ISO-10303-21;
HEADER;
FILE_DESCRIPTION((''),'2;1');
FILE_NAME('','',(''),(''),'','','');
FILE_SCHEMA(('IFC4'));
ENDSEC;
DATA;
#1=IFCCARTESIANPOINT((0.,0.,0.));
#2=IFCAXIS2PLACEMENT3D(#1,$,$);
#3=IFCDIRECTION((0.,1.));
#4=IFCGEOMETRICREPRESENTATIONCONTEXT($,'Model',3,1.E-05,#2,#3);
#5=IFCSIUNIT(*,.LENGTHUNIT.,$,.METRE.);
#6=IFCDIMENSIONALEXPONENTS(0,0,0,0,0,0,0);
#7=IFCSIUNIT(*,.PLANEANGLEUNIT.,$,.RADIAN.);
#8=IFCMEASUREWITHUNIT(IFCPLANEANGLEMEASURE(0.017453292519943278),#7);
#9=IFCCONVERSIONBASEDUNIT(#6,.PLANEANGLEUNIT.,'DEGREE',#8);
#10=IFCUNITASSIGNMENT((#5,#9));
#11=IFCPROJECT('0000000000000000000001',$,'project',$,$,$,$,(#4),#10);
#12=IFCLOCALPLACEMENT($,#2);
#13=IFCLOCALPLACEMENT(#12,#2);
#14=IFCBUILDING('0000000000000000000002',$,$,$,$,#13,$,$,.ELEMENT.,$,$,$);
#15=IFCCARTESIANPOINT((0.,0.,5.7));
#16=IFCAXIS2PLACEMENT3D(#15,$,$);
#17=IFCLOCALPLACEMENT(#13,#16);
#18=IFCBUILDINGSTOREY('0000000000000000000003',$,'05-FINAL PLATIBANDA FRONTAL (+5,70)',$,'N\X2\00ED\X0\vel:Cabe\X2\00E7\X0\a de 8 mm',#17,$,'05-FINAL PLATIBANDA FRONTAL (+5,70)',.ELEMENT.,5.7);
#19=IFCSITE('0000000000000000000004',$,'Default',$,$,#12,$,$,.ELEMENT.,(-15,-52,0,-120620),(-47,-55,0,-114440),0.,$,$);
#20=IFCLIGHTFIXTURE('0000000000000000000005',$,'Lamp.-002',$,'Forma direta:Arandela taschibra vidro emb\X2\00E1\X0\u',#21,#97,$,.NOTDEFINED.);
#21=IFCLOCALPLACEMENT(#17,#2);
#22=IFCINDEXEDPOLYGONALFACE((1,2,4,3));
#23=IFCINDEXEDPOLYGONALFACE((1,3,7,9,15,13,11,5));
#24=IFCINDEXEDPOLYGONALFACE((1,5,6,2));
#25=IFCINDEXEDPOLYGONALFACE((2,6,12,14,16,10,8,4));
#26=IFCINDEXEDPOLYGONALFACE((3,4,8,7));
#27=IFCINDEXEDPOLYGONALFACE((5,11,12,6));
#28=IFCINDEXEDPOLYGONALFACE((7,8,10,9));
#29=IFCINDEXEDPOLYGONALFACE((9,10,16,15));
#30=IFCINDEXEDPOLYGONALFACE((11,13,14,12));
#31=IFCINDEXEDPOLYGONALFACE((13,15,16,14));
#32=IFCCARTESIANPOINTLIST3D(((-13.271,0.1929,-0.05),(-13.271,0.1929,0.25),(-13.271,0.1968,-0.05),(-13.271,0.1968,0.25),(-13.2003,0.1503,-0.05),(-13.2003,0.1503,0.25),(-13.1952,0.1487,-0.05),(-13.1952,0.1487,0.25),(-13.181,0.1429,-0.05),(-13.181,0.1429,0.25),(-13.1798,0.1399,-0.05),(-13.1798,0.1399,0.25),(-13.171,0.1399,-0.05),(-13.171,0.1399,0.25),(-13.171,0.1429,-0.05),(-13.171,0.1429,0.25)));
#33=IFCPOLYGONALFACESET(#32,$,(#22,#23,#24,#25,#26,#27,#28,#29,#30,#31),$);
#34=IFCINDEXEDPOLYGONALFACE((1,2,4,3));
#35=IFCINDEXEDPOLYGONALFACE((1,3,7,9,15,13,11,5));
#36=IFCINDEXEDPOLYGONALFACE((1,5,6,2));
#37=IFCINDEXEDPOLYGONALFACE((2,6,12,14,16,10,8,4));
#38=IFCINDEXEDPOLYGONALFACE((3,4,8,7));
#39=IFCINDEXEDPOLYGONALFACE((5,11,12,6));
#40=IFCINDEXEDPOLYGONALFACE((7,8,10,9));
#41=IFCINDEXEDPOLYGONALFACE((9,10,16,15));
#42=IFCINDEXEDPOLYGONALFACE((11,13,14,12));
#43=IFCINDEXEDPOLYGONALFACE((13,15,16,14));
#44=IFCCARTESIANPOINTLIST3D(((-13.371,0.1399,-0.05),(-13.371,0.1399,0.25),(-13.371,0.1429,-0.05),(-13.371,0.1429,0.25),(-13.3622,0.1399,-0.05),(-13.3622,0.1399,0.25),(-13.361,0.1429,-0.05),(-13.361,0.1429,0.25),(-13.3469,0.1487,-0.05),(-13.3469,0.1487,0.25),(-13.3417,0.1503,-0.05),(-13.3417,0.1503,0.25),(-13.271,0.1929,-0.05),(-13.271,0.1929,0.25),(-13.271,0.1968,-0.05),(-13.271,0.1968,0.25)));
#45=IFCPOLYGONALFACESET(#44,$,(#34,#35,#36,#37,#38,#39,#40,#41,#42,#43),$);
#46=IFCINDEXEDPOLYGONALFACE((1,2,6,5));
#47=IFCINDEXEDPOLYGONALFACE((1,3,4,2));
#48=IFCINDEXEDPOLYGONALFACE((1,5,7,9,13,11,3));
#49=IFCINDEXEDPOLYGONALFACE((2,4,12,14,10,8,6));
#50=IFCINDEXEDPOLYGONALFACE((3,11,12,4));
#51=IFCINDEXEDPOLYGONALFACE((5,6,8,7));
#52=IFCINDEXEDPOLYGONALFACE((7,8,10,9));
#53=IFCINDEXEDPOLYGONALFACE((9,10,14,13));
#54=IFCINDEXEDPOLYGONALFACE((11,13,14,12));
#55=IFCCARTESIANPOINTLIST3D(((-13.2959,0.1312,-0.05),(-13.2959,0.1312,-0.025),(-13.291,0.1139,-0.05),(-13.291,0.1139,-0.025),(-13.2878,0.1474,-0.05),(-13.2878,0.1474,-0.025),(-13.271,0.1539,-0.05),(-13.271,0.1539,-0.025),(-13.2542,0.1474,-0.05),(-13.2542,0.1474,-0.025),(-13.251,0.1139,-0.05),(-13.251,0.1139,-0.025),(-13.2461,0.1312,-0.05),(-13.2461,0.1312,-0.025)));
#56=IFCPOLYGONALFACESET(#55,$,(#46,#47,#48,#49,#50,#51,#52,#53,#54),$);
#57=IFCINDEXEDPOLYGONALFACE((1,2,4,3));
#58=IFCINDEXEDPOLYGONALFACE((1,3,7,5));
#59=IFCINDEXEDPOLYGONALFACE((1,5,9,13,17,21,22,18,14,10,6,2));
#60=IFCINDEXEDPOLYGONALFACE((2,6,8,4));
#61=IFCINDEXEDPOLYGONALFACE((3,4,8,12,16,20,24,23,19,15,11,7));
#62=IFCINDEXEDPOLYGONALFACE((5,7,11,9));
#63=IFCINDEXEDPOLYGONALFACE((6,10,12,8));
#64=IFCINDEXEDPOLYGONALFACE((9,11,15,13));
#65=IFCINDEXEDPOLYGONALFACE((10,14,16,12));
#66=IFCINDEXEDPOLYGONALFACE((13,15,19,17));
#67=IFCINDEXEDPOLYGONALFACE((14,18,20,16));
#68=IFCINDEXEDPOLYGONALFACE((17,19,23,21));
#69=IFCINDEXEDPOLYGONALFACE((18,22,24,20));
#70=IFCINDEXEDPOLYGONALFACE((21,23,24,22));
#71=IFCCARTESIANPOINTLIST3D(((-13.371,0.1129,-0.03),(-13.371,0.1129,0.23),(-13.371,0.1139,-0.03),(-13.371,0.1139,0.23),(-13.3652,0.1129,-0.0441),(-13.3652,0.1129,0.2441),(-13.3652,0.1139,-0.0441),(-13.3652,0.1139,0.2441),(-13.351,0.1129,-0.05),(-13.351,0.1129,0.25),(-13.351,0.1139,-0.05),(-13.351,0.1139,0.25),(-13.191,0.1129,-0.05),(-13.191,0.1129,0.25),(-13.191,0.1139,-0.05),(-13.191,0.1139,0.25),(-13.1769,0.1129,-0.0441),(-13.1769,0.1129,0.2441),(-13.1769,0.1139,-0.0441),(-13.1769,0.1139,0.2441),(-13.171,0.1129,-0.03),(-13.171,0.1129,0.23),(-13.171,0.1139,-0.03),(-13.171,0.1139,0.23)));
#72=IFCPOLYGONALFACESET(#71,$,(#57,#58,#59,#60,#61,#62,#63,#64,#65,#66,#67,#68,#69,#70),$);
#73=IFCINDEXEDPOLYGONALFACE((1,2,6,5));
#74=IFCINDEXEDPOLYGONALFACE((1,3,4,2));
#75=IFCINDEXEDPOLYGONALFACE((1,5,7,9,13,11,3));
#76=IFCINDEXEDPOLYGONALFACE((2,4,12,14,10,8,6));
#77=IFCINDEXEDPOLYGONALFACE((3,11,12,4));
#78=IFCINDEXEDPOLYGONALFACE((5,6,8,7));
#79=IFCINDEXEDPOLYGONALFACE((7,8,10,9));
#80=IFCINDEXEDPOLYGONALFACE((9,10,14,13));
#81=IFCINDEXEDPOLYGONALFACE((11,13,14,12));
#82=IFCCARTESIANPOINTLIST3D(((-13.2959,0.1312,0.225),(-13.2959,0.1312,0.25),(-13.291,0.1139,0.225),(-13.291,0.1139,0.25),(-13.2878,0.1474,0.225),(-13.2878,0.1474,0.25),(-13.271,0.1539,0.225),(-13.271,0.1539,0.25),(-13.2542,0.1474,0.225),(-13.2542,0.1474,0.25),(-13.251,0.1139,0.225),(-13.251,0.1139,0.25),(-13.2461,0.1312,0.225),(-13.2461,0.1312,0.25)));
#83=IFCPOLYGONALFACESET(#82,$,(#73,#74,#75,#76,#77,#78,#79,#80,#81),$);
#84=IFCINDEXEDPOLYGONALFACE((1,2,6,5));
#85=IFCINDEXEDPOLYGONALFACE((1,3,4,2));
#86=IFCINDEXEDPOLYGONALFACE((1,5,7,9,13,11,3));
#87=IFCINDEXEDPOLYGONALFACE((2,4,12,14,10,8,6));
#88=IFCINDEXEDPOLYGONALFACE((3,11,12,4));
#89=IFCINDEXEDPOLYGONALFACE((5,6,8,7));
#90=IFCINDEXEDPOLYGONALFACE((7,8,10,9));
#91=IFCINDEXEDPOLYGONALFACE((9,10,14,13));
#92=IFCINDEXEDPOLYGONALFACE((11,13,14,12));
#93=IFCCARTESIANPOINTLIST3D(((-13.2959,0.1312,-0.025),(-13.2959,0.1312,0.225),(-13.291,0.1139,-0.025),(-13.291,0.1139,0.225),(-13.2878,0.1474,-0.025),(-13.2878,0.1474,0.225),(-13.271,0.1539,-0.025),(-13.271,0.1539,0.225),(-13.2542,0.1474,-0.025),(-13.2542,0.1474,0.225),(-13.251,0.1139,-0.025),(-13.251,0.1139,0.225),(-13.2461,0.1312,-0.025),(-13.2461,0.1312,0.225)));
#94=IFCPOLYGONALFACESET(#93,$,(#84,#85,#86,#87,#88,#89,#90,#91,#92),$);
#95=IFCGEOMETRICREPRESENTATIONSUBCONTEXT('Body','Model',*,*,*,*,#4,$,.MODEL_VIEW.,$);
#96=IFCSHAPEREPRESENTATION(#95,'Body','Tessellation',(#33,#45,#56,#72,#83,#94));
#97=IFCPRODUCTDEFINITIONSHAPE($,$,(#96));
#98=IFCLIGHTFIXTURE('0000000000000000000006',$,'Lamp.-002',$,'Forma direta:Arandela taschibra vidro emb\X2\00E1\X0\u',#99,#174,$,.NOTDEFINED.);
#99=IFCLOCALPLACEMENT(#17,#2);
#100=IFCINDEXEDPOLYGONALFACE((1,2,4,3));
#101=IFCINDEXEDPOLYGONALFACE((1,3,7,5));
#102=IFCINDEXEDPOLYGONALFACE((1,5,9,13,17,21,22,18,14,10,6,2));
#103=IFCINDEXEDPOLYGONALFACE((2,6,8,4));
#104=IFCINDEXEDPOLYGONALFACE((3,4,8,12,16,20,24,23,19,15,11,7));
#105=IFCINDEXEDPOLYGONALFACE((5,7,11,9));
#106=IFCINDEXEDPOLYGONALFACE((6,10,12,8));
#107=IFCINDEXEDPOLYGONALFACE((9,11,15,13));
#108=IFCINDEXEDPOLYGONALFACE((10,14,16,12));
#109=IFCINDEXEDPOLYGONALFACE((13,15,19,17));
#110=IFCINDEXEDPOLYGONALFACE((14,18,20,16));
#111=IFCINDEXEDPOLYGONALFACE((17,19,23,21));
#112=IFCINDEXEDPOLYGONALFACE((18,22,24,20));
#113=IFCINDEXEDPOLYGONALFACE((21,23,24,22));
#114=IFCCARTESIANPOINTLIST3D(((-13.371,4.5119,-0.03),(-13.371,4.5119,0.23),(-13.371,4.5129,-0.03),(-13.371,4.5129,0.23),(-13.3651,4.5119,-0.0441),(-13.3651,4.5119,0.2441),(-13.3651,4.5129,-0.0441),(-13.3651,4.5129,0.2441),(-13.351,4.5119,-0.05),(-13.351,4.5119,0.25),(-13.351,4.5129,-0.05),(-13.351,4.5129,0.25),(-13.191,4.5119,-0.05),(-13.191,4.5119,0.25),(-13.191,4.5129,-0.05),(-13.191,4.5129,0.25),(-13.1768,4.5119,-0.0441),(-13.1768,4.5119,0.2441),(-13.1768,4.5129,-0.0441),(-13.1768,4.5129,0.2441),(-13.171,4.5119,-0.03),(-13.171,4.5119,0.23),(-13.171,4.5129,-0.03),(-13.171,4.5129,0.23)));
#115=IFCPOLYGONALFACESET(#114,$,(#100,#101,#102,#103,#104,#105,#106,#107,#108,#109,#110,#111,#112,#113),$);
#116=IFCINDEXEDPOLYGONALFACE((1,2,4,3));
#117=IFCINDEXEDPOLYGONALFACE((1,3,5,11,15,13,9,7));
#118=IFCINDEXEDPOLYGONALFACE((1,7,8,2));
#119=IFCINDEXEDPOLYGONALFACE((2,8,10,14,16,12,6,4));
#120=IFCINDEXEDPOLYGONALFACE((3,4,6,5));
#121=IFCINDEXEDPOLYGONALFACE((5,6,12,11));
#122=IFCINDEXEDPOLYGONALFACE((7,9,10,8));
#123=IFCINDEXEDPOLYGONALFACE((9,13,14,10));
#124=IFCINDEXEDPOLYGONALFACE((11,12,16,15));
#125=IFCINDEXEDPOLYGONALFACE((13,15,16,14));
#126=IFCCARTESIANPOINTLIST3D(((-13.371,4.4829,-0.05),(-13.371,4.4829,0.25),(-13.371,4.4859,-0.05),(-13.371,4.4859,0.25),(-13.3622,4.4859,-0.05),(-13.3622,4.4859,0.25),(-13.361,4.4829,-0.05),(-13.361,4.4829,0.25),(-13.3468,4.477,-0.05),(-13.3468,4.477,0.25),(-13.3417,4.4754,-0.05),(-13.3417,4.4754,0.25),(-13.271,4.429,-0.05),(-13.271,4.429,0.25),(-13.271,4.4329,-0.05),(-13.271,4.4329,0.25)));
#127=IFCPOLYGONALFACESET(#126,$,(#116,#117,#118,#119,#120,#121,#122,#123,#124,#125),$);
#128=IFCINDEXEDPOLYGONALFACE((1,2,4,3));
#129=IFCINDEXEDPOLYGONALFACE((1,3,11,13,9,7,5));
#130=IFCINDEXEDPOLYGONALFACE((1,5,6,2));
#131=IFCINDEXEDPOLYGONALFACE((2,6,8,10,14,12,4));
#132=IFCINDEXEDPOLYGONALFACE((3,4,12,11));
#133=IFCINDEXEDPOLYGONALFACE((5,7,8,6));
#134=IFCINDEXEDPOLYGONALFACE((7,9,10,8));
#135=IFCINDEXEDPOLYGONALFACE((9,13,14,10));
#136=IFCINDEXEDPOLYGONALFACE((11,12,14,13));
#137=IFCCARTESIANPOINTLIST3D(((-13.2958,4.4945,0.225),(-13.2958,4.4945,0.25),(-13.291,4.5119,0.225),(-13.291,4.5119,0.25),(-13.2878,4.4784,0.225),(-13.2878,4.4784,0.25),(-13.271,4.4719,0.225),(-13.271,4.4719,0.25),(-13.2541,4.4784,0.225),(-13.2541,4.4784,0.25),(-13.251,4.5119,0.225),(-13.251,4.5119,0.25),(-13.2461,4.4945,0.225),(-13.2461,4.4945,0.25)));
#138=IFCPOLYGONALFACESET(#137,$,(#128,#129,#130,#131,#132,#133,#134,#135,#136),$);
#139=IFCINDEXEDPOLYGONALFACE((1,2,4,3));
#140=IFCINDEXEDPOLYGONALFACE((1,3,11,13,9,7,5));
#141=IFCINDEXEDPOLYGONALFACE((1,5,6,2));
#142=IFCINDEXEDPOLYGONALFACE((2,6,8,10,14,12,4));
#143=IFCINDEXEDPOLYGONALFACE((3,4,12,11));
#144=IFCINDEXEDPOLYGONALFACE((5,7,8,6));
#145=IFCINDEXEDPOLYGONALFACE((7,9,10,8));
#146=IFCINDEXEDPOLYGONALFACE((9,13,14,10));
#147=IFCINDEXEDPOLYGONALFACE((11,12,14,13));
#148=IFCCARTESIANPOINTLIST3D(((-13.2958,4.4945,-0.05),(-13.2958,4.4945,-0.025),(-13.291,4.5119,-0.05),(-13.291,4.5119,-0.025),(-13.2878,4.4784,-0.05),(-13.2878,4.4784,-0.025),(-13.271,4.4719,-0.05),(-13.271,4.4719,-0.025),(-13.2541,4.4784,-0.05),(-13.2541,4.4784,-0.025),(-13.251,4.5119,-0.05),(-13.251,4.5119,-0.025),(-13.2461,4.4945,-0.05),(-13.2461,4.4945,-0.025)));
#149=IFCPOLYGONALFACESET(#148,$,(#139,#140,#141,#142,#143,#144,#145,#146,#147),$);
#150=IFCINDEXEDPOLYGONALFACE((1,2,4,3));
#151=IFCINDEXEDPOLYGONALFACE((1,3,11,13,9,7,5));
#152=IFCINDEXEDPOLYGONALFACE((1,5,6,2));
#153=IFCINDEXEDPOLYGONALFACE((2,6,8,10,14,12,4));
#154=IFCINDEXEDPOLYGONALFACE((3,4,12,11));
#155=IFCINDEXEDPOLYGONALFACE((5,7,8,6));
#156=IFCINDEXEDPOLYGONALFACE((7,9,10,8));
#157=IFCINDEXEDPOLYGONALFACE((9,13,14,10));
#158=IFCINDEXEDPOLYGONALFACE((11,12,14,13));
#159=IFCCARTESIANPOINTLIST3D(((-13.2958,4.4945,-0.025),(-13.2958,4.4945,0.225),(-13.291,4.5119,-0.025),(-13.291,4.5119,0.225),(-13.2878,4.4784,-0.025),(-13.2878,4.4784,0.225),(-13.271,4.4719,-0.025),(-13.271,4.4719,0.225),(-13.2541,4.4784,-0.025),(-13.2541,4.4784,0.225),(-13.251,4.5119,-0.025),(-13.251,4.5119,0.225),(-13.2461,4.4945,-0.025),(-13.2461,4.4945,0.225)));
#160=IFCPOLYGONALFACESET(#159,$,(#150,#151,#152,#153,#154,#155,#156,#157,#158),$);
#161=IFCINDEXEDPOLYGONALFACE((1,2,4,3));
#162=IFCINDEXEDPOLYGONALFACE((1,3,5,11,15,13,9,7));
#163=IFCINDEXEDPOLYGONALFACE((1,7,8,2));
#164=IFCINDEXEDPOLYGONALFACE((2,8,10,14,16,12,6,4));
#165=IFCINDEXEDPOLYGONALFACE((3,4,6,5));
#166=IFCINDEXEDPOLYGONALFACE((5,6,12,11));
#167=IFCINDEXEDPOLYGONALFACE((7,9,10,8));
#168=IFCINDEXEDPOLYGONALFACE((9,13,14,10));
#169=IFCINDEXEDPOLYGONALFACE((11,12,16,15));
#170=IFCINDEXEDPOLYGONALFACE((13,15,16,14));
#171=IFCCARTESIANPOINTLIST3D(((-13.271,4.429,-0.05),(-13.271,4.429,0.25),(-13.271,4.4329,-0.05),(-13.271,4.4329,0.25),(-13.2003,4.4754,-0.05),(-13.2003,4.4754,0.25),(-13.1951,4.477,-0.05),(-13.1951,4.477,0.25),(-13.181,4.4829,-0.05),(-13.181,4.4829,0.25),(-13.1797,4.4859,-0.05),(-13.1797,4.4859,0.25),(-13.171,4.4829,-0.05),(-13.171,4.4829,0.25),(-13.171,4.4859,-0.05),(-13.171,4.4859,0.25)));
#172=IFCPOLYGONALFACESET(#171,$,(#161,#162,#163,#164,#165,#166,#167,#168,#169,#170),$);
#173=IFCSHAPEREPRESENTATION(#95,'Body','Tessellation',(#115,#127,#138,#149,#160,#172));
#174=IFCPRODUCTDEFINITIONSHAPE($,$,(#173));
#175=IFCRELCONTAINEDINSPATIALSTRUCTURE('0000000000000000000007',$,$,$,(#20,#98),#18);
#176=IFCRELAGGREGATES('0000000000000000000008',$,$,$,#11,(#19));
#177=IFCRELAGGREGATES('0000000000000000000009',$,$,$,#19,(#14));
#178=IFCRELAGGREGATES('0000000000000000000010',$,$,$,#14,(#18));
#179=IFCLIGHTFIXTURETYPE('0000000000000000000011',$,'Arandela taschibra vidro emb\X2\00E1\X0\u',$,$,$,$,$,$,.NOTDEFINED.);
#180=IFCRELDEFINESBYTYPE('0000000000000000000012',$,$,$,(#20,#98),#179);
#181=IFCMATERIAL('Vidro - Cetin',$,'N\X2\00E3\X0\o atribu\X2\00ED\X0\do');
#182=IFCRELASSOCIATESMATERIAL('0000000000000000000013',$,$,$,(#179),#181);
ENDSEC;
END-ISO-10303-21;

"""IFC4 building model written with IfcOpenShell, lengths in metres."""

from ifc_helpers import new_model, entity, si_unit, converted_unit, direction, frame, origin, place, context, subcontext, project, spatial, indexed_curve, outline, extrude, material, type_object, element, save


model = new_model("IFC4")

# Units and contexts
model_context = context("Model", 3, precision=1e-05, world=origin(), true_north=direction((0.0, 1.0)))
body_context = subcontext(model_context, "Body", "Model", "MODEL_VIEW")
ifc_project = project(units=[si_unit("LENGTHUNIT", "METRE"), converted_unit("PLANEANGLEUNIT", "DEGREE", entity("IfcPlaneAngleMeasure", 0.017453292519943278), si_unit("PLANEANGLEUNIT", "RADIAN"), dimensions=[0, 0, 0, 0, 0, 0, 0])], contexts=[model_context])

# Site, building, storey
site_placement = place(None, origin())
site = spatial("IfcSite", under=ifc_project, at=site_placement, Name="Default", CompositionType="ELEMENT", RefLatitude=(-15, -52, 0, -120620), RefLongitude=(-47, -55, 0, -114440), RefElevation=0.0)
building_placement = place(site_placement, origin())
building = spatial("IfcBuilding", under=site, at=building_placement, CompositionType="ELEMENT")
storey_placement = place(building_placement, frame((0.0, 0.0, 5.7)))
storey = spatial("IfcBuildingStorey", under=building, at=storey_placement, Name="05-FINAL PLATIBANDA FRONTAL (+5,70)", ObjectType="Nível:Cabeça de 8 mm", LongName="05-FINAL PLATIBANDA FRONTAL (+5,70)", CompositionType="ELEMENT", Elevation=5.7)

# Light fixtures
ifc_material_1 = material(Name="Vidro - Cetin", Category="Não atribuído")
light_fixture_type_1 = type_object("IfcLightFixtureType", Name="Arandela taschibra vidro embáu", PredefinedType="NOTDEFINED", material=ifc_material_1)
light_fixture_1_placement = place(storey_placement, origin())
element("IfcLightFixture", 1, at=light_fixture_1_placement, inside=storey, type_object=light_fixture_type_1, Name="Lamp.-002", ObjectType="Forma direta:Arandela taschibra vidro embáu", PredefinedType="NOTDEFINED", context=body_context, shape_type="SweptSolid", body=[
    extrude(outline(indexed_curve([(-0.0169, -0.034), (-0.0139, -0.034), (-0.0139, -0.024), (-0.008, -0.0099), (0.04, 0.066), (0.0361, 0.066), (-0.0065, -0.0047), (-0.0169, -0.0253), (-0.0169, -0.034)], self_intersect=False)), frame((-13.205, 0.1568, -0.05), z_axis=(0.0, 0.0, 1.0), x_axis=(0.000013, 1.0, 0.0)), (0.0, 0.0, 1.0), 0.3),
    extrude(outline(indexed_curve([(-0.034, -0.0169), (-0.0253, -0.0169), (-0.0047, -0.0065), (0.066, 0.0361), (0.066, 0.04), (-0.0099, -0.008), (-0.024, -0.0139), (-0.034, -0.0139), (-0.034, -0.0169)], self_intersect=False)), frame((-13.337, 0.1568, -0.05), z_axis=(0.0, 0.0, 1.0), x_axis=(1.0, 0.000426, 0.0)), (0.0, 0.0, 1.0), 0.3),
    extrude(outline(indexed_curve([(-0.02, -0.0202), (0.02, -0.0202), (0.0249, -0.0029), (0.0168, 0.0132), (0.0, 0.0198), (-0.0168, 0.0132), (-0.0249, -0.0029), (-0.02, -0.0202)], self_intersect=False)), frame((-13.271, 0.1341, -0.05)), (0.0, 0.0, 1.0), 0.025),
    extrude(outline(indexed_curve([(-0.08, -0.15), (0.08, -0.15), (0.0941, -0.1441), (0.1, -0.13), (0.1, 0.13), (0.0941, 0.1441), (0.08, 0.15), (-0.08, 0.15), (-0.0941, 0.1441), (-0.1, 0.13), (-0.1, -0.13), (-0.0941, -0.1441), (-0.08, -0.15)], self_intersect=False)), frame((-13.271, 0.1129, 0.1), z_axis=(0.000013, 1.0, 0.0), x_axis=(-1.0, 0.000013, 0.0)), (0.0, 0.0, 1.0), 0.001),
    extrude(outline(indexed_curve([(-0.02, -0.0202), (0.02, -0.0202), (0.0249, -0.0029), (0.0168, 0.0132), (0.0, 0.0198), (-0.0168, 0.0132), (-0.0249, -0.0029), (-0.02, -0.0202)], self_intersect=False)), frame((-13.271, 0.1341, 0.225)), (0.0, 0.0, 1.0), 0.025),
    extrude(outline(indexed_curve([(-0.02, -0.0202), (0.02, -0.0202), (0.0249, -0.0029), (0.0168, 0.0132), (0.0, 0.0198), (-0.0168, 0.0132), (-0.0249, -0.0029), (-0.02, -0.0202)], self_intersect=False)), frame((-13.271, 0.1341, -0.025)), (0.0, 0.0, 1.0), 0.25),
])
light_fixture_2_placement = place(storey_placement, origin())
element("IfcLightFixture", 2, at=light_fixture_2_placement, inside=storey, type_object=light_fixture_type_1, Name="Lamp.-002", ObjectType="Forma direta:Arandela taschibra vidro embáu", PredefinedType="NOTDEFINED", context=body_context, shape_type="SweptSolid", body=[
    extrude(outline(indexed_curve([(-0.08, -0.15), (0.08, -0.15), (0.0941, -0.1441), (0.1, -0.13), (0.1, 0.13), (0.0941, 0.1441), (0.08, 0.15), (-0.08, 0.15), (-0.0941, 0.1441), (-0.1, 0.13), (-0.1, -0.13), (-0.0941, -0.1441), (-0.08, -0.15)], self_intersect=False)), frame((-13.271, 4.5119, 0.1), z_axis=(0.000013, 1.0, 0.0), x_axis=(-1.0, 0.000013, 0.0)), (0.0, 0.0, 1.0), 0.001),
    extrude(outline(indexed_curve([(-0.0169, -0.034), (-0.0139, -0.034), (-0.0139, -0.024), (-0.008, -0.0099), (0.04, 0.066), (0.0361, 0.066), (-0.0065, -0.0047), (-0.0169, -0.0253), (-0.0169, -0.034)], self_intersect=False)), frame((-13.3369, 4.469, -0.05), z_axis=(0.0, 0.0, 1.0), x_axis=(-0.000013, -1.0, 0.0)), (0.0, 0.0, 1.0), 0.3),
    extrude(outline(indexed_curve([(-0.0141, -0.0247), (0.004, -0.0247), (0.0173, -0.0126), (0.019, 0.0054), (0.0082, 0.0198), (-0.0095, 0.0232), (-0.0249, 0.0138), (-0.0141, -0.0247)], self_intersect=False)), frame((-13.271, 4.4916, 0.225), z_axis=(0.0, 0.0, 1.0), x_axis=(-0.271031, -0.96257, 0.0)), (0.0, 0.0, 1.0), 0.025),
    extrude(outline(indexed_curve([(-0.0141, -0.0247), (0.004, -0.0247), (0.0173, -0.0126), (0.019, 0.0054), (0.0082, 0.0198), (-0.0095, 0.0232), (-0.0249, 0.0138), (-0.0141, -0.0247)], self_intersect=False)), frame((-13.271, 4.4916, -0.05), z_axis=(0.0, 0.0, 1.0), x_axis=(-0.271031, -0.96257, 0.0)), (0.0, 0.0, 1.0), 0.025),
    extrude(outline(indexed_curve([(-0.0141, -0.0247), (0.004, -0.0247), (0.0173, -0.0126), (0.019, 0.0054), (0.0082, 0.0198), (-0.0095, 0.0232), (-0.0249, 0.0138), (-0.0141, -0.0247)], self_intersect=False)), frame((-13.271, 4.4916, -0.025), z_axis=(0.0, 0.0, 1.0), x_axis=(-0.271031, -0.96257, 0.0)), (0.0, 0.0, 1.0), 0.25),
    extrude(outline(indexed_curve([(-0.034, -0.0169), (-0.0253, -0.0169), (-0.0047, -0.0065), (0.066, 0.0361), (0.066, 0.04), (-0.0099, -0.008), (-0.024, -0.0139), (-0.034, -0.0139), (-0.034, -0.0169)], self_intersect=False)), frame((-13.205, 4.469, -0.05), z_axis=(0.0, 0.0, 1.0), x_axis=(-1.0, -0.000426, 0.0)), (0.0, 0.0, 1.0), 0.3),
])

save(model, "model.ifc")
